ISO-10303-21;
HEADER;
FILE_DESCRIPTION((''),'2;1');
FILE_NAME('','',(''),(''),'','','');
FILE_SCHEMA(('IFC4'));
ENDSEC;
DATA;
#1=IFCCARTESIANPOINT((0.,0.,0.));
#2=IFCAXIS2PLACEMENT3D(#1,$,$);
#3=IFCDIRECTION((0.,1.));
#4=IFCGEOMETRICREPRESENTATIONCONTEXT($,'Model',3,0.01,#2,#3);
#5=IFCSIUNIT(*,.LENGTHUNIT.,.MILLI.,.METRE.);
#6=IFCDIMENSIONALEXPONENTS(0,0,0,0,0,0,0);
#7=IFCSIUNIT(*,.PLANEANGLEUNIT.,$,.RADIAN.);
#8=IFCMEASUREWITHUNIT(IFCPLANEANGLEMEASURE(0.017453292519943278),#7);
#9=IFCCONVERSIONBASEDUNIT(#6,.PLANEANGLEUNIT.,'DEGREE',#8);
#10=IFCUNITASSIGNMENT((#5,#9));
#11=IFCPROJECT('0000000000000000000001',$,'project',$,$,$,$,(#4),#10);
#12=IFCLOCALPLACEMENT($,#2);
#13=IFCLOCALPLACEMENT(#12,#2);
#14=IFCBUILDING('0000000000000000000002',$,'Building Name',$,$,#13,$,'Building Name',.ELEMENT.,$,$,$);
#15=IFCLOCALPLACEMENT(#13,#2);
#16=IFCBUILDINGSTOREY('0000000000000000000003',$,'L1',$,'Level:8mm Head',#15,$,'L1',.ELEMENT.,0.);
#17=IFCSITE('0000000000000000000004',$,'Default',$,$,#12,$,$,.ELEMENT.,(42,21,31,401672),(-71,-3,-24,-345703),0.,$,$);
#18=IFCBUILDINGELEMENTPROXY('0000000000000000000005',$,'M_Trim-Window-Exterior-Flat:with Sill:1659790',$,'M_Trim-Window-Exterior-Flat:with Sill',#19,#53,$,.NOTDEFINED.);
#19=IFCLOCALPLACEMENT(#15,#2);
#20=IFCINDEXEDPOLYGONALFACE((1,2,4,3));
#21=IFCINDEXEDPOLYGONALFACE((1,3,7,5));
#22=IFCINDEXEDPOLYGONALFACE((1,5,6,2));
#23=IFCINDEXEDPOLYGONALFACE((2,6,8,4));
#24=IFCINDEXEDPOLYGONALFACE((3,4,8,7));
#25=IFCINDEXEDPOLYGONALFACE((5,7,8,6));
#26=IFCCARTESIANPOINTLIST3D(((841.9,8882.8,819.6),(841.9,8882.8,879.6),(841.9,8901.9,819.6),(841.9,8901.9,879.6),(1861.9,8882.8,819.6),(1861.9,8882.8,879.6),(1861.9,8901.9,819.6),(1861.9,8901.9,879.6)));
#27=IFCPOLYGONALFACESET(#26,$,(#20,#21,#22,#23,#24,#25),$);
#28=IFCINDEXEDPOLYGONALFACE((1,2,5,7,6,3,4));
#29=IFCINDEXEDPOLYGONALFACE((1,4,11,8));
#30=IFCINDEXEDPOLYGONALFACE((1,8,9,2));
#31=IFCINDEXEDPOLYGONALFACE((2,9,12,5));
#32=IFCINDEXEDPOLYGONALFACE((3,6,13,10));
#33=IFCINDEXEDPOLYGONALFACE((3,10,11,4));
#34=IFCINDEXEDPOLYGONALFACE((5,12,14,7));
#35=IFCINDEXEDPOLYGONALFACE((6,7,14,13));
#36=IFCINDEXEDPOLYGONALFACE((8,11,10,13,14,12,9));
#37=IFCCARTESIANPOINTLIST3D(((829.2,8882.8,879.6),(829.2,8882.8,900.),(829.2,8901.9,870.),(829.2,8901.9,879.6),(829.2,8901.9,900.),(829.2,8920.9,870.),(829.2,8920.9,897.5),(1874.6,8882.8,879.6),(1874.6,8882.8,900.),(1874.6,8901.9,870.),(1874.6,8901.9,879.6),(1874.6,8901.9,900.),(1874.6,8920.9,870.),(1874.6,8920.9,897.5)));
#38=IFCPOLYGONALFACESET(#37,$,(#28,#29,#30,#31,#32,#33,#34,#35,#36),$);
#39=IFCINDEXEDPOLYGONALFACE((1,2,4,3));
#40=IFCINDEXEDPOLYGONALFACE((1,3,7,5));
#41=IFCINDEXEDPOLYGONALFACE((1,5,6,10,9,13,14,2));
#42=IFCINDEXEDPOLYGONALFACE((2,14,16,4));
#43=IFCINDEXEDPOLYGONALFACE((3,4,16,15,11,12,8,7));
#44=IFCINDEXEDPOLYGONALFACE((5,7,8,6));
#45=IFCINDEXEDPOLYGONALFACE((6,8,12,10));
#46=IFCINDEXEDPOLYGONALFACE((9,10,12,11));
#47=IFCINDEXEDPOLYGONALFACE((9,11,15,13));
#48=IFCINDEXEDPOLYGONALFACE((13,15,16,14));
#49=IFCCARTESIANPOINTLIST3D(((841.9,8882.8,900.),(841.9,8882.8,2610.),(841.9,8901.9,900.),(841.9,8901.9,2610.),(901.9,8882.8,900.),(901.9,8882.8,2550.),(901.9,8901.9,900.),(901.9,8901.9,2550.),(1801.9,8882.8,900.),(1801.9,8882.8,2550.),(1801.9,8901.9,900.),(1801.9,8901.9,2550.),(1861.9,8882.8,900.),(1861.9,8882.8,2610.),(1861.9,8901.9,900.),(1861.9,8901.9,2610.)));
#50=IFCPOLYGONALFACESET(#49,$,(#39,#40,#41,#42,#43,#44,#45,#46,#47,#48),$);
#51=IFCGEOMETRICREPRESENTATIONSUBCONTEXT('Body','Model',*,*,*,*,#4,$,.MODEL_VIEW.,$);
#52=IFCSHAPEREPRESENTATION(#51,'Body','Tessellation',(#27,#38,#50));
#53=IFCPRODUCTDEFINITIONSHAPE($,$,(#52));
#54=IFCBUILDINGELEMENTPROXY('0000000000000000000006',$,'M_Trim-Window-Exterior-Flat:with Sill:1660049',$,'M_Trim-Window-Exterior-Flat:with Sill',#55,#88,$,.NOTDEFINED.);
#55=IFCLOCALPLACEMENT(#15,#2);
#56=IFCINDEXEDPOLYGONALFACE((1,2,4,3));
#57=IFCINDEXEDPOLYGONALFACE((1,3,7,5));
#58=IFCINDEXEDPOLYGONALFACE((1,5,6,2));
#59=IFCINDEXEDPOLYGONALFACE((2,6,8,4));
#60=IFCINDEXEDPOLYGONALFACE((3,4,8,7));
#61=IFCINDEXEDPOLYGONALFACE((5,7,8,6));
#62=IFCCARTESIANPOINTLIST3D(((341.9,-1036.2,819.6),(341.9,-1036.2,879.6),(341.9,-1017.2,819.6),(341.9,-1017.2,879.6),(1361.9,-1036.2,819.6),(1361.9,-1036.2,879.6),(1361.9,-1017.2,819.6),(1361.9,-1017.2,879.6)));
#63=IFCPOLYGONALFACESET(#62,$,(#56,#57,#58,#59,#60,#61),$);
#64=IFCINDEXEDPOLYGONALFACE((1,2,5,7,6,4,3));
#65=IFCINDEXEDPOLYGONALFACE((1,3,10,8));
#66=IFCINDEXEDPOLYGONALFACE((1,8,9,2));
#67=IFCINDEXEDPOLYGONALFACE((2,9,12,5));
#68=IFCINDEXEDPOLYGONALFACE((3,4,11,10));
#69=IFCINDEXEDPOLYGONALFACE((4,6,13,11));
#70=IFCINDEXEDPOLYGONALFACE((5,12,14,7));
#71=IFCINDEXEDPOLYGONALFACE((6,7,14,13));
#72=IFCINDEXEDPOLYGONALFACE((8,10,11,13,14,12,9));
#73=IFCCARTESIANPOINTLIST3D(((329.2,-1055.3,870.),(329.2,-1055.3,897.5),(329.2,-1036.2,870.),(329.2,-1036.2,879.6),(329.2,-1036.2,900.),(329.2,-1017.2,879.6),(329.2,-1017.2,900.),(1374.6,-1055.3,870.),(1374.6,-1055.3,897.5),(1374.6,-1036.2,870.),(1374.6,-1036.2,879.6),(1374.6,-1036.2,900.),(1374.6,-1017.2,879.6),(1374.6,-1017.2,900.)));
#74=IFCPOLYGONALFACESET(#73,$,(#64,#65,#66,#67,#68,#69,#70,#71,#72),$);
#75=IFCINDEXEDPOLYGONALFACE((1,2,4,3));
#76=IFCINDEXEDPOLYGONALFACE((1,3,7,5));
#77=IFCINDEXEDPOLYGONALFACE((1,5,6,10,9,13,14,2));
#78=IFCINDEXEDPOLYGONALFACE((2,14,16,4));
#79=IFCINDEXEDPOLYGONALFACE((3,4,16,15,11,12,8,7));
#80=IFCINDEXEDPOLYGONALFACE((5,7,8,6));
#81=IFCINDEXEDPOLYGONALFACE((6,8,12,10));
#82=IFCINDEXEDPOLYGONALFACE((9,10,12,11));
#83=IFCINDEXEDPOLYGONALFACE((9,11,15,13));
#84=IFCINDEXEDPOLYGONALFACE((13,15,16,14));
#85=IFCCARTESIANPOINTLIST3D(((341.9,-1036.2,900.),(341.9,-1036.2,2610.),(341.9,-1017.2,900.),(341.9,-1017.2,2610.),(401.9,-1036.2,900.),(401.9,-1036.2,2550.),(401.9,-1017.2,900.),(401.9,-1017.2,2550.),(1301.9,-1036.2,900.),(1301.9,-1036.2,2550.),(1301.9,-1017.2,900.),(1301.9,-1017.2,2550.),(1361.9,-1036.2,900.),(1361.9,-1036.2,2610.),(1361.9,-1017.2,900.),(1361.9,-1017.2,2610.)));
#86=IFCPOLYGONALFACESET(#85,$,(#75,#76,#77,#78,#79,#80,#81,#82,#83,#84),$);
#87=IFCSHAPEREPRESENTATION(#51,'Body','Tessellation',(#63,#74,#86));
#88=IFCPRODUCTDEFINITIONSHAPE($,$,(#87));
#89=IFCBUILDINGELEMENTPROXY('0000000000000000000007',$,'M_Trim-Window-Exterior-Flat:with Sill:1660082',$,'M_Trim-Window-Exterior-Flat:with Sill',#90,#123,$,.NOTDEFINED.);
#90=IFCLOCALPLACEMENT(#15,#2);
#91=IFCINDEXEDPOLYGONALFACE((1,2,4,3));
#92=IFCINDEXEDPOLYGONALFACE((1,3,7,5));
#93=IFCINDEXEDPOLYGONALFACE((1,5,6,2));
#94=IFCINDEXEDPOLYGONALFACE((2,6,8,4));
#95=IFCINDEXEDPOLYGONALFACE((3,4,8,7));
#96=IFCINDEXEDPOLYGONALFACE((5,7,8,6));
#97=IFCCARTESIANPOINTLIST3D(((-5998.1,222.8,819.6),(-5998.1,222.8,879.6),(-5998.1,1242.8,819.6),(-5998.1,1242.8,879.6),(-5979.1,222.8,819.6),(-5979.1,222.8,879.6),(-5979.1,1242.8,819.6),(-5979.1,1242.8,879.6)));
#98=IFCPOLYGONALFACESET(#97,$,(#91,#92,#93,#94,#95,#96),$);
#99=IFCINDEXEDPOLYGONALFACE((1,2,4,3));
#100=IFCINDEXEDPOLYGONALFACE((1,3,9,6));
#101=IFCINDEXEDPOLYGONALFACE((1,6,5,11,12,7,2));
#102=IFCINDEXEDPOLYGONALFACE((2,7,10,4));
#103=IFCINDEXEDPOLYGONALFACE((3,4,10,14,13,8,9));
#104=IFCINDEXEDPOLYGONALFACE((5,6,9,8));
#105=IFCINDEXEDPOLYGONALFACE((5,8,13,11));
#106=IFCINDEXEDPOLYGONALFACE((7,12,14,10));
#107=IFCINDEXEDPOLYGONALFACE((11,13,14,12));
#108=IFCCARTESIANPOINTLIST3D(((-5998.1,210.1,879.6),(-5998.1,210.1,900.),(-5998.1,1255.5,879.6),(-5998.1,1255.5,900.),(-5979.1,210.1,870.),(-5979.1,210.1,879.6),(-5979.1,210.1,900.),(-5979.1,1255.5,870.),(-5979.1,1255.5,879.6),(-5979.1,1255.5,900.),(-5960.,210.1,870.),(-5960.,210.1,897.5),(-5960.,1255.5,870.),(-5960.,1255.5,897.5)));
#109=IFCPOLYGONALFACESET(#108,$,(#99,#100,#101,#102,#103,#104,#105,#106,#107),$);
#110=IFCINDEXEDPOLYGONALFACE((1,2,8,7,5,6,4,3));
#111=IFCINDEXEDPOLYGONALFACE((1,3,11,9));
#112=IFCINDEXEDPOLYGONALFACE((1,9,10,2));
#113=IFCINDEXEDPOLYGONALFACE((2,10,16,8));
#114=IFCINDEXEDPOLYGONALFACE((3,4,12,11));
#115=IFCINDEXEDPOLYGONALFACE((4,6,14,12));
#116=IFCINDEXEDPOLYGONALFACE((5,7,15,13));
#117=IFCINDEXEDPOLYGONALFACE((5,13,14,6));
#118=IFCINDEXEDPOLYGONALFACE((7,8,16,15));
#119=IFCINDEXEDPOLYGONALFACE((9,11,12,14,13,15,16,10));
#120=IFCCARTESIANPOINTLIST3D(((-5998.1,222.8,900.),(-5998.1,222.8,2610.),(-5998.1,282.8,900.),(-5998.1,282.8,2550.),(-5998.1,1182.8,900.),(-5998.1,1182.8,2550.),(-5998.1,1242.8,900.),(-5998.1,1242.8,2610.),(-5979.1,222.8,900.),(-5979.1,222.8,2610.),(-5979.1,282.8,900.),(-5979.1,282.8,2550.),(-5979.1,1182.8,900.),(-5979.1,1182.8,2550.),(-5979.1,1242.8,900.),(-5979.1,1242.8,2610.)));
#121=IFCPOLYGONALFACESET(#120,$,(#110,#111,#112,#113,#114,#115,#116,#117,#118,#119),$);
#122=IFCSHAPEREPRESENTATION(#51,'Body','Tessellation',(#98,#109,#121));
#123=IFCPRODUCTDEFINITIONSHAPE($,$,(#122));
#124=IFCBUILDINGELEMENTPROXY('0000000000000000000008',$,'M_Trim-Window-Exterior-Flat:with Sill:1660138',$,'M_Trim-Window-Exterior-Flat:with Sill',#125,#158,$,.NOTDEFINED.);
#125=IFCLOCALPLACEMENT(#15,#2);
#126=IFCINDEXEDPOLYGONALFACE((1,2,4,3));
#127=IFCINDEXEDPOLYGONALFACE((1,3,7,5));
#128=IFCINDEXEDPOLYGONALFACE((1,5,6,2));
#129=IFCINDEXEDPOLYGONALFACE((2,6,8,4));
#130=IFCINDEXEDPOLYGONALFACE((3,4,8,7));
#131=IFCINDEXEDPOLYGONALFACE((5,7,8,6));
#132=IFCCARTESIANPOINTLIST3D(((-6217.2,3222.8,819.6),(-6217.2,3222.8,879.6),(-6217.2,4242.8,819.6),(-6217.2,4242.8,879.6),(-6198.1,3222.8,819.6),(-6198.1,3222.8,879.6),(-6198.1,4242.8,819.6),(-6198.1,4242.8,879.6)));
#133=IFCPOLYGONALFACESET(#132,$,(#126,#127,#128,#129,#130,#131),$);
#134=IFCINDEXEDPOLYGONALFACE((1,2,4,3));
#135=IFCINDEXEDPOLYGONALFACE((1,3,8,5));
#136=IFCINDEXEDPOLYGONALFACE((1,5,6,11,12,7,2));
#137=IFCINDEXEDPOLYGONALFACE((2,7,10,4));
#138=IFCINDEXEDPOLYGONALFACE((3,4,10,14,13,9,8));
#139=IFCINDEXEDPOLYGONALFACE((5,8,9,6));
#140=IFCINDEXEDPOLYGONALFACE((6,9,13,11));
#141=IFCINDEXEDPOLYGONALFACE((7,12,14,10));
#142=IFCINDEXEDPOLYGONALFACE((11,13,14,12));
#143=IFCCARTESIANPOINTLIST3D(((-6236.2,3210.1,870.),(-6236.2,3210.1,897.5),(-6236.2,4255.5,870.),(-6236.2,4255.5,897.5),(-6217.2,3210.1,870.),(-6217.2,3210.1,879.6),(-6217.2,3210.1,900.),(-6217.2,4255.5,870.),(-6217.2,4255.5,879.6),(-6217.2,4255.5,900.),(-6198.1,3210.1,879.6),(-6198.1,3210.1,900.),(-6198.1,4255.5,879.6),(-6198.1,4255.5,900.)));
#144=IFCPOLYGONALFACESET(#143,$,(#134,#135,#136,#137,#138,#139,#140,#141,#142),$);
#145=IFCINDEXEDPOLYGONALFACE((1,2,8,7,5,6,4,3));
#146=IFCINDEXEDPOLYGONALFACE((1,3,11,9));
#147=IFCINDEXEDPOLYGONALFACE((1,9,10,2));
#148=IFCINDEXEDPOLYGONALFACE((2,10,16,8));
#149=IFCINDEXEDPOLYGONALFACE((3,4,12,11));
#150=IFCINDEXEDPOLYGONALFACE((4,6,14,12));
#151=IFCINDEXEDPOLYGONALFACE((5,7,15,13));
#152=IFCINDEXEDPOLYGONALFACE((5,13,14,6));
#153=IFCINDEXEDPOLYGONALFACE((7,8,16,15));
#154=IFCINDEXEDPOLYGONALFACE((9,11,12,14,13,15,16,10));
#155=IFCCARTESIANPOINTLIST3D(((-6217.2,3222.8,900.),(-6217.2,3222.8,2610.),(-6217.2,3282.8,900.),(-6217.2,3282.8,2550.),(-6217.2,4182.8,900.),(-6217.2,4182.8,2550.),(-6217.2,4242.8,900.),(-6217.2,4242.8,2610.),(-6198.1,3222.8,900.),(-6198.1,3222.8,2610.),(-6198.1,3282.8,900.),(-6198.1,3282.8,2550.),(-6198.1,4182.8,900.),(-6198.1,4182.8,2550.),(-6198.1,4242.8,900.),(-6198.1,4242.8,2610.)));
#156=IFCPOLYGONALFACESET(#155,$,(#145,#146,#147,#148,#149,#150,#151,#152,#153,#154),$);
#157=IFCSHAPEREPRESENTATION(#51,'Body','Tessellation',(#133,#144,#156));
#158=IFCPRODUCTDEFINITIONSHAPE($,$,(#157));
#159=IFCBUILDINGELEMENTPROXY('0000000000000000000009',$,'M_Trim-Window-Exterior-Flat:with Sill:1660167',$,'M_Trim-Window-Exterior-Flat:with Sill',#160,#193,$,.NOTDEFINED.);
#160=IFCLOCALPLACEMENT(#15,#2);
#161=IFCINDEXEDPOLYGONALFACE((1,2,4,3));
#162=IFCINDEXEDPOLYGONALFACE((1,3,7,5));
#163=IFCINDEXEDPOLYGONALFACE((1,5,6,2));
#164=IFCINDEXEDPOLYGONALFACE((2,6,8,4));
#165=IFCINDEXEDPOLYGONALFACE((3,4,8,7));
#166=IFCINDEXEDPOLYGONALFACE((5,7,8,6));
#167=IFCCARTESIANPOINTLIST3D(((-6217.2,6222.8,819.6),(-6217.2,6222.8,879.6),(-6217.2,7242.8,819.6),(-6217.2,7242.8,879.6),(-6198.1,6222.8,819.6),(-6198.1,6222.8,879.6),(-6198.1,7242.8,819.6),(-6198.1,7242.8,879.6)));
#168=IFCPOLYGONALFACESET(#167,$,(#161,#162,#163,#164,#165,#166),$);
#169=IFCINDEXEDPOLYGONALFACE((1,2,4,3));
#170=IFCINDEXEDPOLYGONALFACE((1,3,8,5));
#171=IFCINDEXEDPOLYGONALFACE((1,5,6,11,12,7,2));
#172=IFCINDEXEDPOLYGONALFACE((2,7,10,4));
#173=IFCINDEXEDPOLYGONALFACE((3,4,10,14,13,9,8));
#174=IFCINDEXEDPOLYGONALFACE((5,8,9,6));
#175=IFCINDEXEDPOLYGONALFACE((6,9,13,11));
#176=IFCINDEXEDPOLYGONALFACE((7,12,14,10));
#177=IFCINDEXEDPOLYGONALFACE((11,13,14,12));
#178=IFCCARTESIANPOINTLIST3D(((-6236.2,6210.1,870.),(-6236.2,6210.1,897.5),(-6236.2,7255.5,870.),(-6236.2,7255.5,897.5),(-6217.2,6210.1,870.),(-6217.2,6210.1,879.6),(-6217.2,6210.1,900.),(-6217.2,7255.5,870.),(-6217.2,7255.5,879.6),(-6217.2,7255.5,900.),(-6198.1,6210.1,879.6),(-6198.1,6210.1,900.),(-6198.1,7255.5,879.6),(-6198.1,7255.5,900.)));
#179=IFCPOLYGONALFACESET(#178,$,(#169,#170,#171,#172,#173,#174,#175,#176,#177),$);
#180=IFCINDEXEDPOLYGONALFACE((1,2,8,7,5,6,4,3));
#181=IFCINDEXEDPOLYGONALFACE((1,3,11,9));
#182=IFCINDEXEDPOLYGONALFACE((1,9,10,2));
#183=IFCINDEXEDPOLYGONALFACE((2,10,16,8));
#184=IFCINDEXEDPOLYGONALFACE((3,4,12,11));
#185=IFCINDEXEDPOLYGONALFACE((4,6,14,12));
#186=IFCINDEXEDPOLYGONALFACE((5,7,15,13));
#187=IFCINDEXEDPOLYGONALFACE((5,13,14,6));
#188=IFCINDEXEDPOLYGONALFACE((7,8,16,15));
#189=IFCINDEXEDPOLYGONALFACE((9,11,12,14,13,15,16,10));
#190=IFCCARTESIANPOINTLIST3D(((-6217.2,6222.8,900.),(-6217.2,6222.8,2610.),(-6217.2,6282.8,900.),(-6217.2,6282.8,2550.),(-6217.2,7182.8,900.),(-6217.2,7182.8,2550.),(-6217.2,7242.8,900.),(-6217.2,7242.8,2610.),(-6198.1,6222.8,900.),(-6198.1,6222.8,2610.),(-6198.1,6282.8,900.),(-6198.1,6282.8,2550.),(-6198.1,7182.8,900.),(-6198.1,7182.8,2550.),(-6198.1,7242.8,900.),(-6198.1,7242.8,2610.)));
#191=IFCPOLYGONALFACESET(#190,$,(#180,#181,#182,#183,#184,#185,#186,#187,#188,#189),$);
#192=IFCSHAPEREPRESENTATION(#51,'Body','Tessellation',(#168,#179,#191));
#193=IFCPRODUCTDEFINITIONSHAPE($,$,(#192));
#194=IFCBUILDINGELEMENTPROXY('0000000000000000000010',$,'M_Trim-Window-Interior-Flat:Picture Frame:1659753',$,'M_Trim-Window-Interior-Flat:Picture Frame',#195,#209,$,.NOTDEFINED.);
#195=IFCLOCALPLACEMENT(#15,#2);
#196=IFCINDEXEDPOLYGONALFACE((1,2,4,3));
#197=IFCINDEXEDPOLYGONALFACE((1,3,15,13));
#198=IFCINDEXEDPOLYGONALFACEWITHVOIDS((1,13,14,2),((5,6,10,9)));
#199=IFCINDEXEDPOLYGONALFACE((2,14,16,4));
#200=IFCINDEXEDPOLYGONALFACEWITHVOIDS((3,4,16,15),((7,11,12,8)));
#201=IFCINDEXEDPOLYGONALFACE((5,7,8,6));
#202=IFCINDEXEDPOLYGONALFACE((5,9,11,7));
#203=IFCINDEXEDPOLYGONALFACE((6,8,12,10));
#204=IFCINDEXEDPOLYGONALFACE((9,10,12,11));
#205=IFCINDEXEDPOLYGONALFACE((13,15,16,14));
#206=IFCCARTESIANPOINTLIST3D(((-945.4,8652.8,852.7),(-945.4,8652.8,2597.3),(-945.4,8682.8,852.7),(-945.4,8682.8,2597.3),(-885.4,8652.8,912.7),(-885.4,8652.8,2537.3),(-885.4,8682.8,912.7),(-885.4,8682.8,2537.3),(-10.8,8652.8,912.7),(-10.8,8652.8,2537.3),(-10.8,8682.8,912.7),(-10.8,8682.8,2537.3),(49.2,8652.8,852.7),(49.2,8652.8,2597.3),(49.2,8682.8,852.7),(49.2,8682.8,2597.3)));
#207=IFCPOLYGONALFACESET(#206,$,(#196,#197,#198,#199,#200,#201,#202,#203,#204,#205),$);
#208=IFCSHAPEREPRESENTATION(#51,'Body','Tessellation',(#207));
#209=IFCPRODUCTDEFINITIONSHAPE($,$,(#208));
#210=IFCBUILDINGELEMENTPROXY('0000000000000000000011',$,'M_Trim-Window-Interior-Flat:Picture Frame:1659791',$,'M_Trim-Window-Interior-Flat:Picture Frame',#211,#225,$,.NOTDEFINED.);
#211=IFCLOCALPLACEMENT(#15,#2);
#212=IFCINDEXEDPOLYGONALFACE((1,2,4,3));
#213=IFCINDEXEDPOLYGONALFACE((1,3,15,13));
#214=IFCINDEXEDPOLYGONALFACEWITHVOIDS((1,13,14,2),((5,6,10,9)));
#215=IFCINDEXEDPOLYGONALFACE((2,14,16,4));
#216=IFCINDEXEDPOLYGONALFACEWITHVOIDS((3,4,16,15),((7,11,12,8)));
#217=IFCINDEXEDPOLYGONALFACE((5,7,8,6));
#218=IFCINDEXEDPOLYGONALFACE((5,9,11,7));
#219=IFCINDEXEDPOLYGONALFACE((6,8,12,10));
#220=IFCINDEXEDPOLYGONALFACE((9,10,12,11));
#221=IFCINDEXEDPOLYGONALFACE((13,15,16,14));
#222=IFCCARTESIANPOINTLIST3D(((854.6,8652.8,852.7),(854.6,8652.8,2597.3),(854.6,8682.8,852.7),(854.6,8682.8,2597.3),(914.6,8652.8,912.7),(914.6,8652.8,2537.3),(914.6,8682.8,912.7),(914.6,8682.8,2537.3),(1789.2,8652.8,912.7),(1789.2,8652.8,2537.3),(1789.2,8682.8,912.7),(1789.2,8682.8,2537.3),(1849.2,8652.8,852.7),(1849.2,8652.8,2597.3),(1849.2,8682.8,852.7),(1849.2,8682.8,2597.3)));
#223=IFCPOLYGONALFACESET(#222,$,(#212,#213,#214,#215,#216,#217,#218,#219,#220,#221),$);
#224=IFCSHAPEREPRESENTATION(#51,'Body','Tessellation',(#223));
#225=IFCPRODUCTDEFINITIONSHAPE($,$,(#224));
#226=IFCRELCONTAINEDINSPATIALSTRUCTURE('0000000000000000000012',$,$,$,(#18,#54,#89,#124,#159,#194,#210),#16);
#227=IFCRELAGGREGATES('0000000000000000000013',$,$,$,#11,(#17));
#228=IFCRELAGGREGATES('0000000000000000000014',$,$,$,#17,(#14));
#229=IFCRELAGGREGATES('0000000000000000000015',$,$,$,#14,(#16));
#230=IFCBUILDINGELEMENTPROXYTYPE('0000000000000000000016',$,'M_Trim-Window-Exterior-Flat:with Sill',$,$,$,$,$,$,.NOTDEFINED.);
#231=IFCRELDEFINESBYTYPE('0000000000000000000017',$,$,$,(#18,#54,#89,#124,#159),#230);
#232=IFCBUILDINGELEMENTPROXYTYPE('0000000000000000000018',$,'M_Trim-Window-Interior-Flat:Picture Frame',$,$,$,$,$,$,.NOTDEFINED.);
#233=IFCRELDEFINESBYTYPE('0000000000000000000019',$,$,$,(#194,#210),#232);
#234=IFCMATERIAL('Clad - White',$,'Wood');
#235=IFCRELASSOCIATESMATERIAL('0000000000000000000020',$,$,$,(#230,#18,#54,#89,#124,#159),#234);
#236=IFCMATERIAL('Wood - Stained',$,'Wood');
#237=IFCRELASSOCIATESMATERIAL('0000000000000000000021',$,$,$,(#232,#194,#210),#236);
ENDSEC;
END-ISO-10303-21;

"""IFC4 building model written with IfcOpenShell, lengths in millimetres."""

from ifc_helpers import new_model, entity, si_unit, converted_unit, direction, frame, origin, place, context, subcontext, project, spatial, indexed_curve, outline, extrude, source, transform, mapped, material, type_object, type_shapes, element, save


model = new_model("IFC4")

# Units and contexts
model_context = context("Model", 3, precision=0.01, world=origin(), true_north=direction((0.0, 1.0)))
body_context = subcontext(model_context, "Body", "Model", "MODEL_VIEW")
ifc_project = project(units=[si_unit("LENGTHUNIT", "METRE", prefix="MILLI"), converted_unit("PLANEANGLEUNIT", "DEGREE", entity("IfcPlaneAngleMeasure", 0.017453292519943278), si_unit("PLANEANGLEUNIT", "RADIAN"), dimensions=[0, 0, 0, 0, 0, 0, 0])], contexts=[model_context])

# Site, building, storey
site_placement = place(None, origin())
site = spatial("IfcSite", under=ifc_project, at=site_placement, Name="Default", CompositionType="ELEMENT", RefLatitude=(42, 21, 31, 401672), RefLongitude=(-71, -3, -24, -345703), RefElevation=0.0)
building_placement = place(site_placement, origin())
building = spatial("IfcBuilding", under=site, at=building_placement, Name="Building Name", LongName="Building Name", CompositionType="ELEMENT")
storey_placement = place(building_placement, origin())
storey = spatial("IfcBuildingStorey", under=building, at=storey_placement, Name="L1", ObjectType="Level:8mm Head", LongName="L1", CompositionType="ELEMENT", Elevation=0.0)

# Building element proxies
ifc_material_1 = material(Name="Clad - White", Category="Wood")
ifc_material_2 = material(Name="Wood - Stained", Category="Wood")
building_element_proxy_type_1 = type_object("IfcBuildingElementProxyType", Name="M_Trim-Window-Exterior-Flat:with Sill", PredefinedType="NOTDEFINED", material=ifc_material_1)
shared_shape_1 = source(origin(), body_context, "Body", "SweptSolid", [
    extrude(outline(indexed_curve([(-510.0, -30.0), (510.0, -30.0), (510.0, 30.0), (-510.0, 30.0), (-510.0, -30.0)], self_intersect=False)), frame((0.0, -1700.4, 0.0), z_axis=(0.0, 0.0, 1.0), x_axis=(-1.0, 0.0, 0.0)), (0.0, 0.0, 1.0), 19.0),
    extrude(outline(indexed_curve([(-19.0, -15.2), (0.0, -15.2), (0.0, -5.7), (19.0, -5.7), (19.0, 14.8), (0.0, 14.8), (-19.0, 12.3), (-19.0, -15.2)], self_intersect=False)), frame((-522.7, -1664.8, 19.0), z_axis=(1.0, 0.0, 0.0), x_axis=(0.0, 0.0, -1.0)), (0.0, 0.0, 1.0), 1045.4),
    extrude(outline(indexed_curve([(-870.0, -510.0), (840.0, -510.0), (840.0, -450.0), (-810.0, -450.0), (-810.0, 450.0), (840.0, 450.0), (840.0, 510.0), (-870.0, 510.0), (-870.0, -510.0)], self_intersect=False)), frame((0.0, -810.0, 0.0), z_axis=(0.0, 0.0, 1.0), x_axis=(0.0, -1.0, 0.0)), (0.0, 0.0, 1.0), 19.0),
])
type_shapes(building_element_proxy_type_1, [shared_shape_1])
for number, where, z_axis, x_axis, name in (
    (1, (1351.9, 8882.8, 2550.0), (0.0, 1.0, 0.0), (-1.0, 0.0, 0.0), "M_Trim-Window-Exterior-Flat:with Sill:1659790"),
    (2, (851.9, -1017.2, 2550.0), (0.0, -1.0, 0.0), (1.0, 0.0, 0.0), "M_Trim-Window-Exterior-Flat:with Sill:1660049"),
    (3, (-5998.1, 732.8, 2550.0), (1.0, 0.0, 0.0), (0.0, 1.0, 0.0), "M_Trim-Window-Exterior-Flat:with Sill:1660082"),
    (4, (-6198.1, 3732.8, 2550.0), (-1.0, 0.0, 0.0), (0.0, -1.0, 0.0), "M_Trim-Window-Exterior-Flat:with Sill:1660138"),
    (5, (-6198.1, 6732.8, 2550.0), (-1.0, 0.0, 0.0), (0.0, -1.0, 0.0), "M_Trim-Window-Exterior-Flat:with Sill:1660167"),
):
    element("IfcBuildingElementProxy", number, at=place(storey_placement, frame(where, z_axis=z_axis, x_axis=x_axis)), inside=storey, type_object=building_element_proxy_type_1, material=ifc_material_1, Name=name, ObjectType="M_Trim-Window-Exterior-Flat:with Sill", PredefinedType="NOTDEFINED", context=body_context, shape_type="MappedRepresentation", body=[
        mapped(shared_shape_1, transform((0.0, 0.0, 0.0), scale=1.0)),
    ])
building_element_proxy_type_2 = type_object("IfcBuildingElementProxyType", Name="M_Trim-Window-Interior-Flat:Picture Frame", PredefinedType="NOTDEFINED", material=ifc_material_2)
shared_shape_2 = source(origin(), body_context, "Body", "SweptSolid", [
    extrude(outline(indexed_curve([(-497.3, -872.3), (497.3, -872.3), (497.3, 872.3), (-497.3, 872.3), (-497.3, -872.3)], self_intersect=False), holes=[indexed_curve([(-437.3, -812.3), (-437.3, 812.3), (437.3, 812.3), (437.3, -812.3), (-437.3, -812.3)], self_intersect=False)]), frame((0.0, -825.0, 0.0), z_axis=(0.0, 0.0, 1.0), x_axis=(-1.0, 0.0, 0.0)), (0.0, 0.0, 1.0), 30.0),
])
type_shapes(building_element_proxy_type_2, [shared_shape_2])
for number, where, z_axis, x_axis, name in (
    (6, (-448.1, 8682.8, 2550.0), (0.0, -1.0, 0.0), (1.0, 0.0, 0.0), "M_Trim-Window-Interior-Flat:Picture Frame:1659753"),
    (7, (1351.9, 8682.8, 2550.0), (0.0, -1.0, 0.0), (1.0, 0.0, 0.0), "M_Trim-Window-Interior-Flat:Picture Frame:1659791"),
):
    element("IfcBuildingElementProxy", number, at=place(storey_placement, frame(where, z_axis=z_axis, x_axis=x_axis)), inside=storey, type_object=building_element_proxy_type_2, material=ifc_material_2, Name=name, ObjectType="M_Trim-Window-Interior-Flat:Picture Frame", PredefinedType="NOTDEFINED", context=body_context, shape_type="MappedRepresentation", body=[
        mapped(shared_shape_2, transform((0.0, 0.0, 0.0), scale=1.0)),
    ])

save(model, "model.ifc")
